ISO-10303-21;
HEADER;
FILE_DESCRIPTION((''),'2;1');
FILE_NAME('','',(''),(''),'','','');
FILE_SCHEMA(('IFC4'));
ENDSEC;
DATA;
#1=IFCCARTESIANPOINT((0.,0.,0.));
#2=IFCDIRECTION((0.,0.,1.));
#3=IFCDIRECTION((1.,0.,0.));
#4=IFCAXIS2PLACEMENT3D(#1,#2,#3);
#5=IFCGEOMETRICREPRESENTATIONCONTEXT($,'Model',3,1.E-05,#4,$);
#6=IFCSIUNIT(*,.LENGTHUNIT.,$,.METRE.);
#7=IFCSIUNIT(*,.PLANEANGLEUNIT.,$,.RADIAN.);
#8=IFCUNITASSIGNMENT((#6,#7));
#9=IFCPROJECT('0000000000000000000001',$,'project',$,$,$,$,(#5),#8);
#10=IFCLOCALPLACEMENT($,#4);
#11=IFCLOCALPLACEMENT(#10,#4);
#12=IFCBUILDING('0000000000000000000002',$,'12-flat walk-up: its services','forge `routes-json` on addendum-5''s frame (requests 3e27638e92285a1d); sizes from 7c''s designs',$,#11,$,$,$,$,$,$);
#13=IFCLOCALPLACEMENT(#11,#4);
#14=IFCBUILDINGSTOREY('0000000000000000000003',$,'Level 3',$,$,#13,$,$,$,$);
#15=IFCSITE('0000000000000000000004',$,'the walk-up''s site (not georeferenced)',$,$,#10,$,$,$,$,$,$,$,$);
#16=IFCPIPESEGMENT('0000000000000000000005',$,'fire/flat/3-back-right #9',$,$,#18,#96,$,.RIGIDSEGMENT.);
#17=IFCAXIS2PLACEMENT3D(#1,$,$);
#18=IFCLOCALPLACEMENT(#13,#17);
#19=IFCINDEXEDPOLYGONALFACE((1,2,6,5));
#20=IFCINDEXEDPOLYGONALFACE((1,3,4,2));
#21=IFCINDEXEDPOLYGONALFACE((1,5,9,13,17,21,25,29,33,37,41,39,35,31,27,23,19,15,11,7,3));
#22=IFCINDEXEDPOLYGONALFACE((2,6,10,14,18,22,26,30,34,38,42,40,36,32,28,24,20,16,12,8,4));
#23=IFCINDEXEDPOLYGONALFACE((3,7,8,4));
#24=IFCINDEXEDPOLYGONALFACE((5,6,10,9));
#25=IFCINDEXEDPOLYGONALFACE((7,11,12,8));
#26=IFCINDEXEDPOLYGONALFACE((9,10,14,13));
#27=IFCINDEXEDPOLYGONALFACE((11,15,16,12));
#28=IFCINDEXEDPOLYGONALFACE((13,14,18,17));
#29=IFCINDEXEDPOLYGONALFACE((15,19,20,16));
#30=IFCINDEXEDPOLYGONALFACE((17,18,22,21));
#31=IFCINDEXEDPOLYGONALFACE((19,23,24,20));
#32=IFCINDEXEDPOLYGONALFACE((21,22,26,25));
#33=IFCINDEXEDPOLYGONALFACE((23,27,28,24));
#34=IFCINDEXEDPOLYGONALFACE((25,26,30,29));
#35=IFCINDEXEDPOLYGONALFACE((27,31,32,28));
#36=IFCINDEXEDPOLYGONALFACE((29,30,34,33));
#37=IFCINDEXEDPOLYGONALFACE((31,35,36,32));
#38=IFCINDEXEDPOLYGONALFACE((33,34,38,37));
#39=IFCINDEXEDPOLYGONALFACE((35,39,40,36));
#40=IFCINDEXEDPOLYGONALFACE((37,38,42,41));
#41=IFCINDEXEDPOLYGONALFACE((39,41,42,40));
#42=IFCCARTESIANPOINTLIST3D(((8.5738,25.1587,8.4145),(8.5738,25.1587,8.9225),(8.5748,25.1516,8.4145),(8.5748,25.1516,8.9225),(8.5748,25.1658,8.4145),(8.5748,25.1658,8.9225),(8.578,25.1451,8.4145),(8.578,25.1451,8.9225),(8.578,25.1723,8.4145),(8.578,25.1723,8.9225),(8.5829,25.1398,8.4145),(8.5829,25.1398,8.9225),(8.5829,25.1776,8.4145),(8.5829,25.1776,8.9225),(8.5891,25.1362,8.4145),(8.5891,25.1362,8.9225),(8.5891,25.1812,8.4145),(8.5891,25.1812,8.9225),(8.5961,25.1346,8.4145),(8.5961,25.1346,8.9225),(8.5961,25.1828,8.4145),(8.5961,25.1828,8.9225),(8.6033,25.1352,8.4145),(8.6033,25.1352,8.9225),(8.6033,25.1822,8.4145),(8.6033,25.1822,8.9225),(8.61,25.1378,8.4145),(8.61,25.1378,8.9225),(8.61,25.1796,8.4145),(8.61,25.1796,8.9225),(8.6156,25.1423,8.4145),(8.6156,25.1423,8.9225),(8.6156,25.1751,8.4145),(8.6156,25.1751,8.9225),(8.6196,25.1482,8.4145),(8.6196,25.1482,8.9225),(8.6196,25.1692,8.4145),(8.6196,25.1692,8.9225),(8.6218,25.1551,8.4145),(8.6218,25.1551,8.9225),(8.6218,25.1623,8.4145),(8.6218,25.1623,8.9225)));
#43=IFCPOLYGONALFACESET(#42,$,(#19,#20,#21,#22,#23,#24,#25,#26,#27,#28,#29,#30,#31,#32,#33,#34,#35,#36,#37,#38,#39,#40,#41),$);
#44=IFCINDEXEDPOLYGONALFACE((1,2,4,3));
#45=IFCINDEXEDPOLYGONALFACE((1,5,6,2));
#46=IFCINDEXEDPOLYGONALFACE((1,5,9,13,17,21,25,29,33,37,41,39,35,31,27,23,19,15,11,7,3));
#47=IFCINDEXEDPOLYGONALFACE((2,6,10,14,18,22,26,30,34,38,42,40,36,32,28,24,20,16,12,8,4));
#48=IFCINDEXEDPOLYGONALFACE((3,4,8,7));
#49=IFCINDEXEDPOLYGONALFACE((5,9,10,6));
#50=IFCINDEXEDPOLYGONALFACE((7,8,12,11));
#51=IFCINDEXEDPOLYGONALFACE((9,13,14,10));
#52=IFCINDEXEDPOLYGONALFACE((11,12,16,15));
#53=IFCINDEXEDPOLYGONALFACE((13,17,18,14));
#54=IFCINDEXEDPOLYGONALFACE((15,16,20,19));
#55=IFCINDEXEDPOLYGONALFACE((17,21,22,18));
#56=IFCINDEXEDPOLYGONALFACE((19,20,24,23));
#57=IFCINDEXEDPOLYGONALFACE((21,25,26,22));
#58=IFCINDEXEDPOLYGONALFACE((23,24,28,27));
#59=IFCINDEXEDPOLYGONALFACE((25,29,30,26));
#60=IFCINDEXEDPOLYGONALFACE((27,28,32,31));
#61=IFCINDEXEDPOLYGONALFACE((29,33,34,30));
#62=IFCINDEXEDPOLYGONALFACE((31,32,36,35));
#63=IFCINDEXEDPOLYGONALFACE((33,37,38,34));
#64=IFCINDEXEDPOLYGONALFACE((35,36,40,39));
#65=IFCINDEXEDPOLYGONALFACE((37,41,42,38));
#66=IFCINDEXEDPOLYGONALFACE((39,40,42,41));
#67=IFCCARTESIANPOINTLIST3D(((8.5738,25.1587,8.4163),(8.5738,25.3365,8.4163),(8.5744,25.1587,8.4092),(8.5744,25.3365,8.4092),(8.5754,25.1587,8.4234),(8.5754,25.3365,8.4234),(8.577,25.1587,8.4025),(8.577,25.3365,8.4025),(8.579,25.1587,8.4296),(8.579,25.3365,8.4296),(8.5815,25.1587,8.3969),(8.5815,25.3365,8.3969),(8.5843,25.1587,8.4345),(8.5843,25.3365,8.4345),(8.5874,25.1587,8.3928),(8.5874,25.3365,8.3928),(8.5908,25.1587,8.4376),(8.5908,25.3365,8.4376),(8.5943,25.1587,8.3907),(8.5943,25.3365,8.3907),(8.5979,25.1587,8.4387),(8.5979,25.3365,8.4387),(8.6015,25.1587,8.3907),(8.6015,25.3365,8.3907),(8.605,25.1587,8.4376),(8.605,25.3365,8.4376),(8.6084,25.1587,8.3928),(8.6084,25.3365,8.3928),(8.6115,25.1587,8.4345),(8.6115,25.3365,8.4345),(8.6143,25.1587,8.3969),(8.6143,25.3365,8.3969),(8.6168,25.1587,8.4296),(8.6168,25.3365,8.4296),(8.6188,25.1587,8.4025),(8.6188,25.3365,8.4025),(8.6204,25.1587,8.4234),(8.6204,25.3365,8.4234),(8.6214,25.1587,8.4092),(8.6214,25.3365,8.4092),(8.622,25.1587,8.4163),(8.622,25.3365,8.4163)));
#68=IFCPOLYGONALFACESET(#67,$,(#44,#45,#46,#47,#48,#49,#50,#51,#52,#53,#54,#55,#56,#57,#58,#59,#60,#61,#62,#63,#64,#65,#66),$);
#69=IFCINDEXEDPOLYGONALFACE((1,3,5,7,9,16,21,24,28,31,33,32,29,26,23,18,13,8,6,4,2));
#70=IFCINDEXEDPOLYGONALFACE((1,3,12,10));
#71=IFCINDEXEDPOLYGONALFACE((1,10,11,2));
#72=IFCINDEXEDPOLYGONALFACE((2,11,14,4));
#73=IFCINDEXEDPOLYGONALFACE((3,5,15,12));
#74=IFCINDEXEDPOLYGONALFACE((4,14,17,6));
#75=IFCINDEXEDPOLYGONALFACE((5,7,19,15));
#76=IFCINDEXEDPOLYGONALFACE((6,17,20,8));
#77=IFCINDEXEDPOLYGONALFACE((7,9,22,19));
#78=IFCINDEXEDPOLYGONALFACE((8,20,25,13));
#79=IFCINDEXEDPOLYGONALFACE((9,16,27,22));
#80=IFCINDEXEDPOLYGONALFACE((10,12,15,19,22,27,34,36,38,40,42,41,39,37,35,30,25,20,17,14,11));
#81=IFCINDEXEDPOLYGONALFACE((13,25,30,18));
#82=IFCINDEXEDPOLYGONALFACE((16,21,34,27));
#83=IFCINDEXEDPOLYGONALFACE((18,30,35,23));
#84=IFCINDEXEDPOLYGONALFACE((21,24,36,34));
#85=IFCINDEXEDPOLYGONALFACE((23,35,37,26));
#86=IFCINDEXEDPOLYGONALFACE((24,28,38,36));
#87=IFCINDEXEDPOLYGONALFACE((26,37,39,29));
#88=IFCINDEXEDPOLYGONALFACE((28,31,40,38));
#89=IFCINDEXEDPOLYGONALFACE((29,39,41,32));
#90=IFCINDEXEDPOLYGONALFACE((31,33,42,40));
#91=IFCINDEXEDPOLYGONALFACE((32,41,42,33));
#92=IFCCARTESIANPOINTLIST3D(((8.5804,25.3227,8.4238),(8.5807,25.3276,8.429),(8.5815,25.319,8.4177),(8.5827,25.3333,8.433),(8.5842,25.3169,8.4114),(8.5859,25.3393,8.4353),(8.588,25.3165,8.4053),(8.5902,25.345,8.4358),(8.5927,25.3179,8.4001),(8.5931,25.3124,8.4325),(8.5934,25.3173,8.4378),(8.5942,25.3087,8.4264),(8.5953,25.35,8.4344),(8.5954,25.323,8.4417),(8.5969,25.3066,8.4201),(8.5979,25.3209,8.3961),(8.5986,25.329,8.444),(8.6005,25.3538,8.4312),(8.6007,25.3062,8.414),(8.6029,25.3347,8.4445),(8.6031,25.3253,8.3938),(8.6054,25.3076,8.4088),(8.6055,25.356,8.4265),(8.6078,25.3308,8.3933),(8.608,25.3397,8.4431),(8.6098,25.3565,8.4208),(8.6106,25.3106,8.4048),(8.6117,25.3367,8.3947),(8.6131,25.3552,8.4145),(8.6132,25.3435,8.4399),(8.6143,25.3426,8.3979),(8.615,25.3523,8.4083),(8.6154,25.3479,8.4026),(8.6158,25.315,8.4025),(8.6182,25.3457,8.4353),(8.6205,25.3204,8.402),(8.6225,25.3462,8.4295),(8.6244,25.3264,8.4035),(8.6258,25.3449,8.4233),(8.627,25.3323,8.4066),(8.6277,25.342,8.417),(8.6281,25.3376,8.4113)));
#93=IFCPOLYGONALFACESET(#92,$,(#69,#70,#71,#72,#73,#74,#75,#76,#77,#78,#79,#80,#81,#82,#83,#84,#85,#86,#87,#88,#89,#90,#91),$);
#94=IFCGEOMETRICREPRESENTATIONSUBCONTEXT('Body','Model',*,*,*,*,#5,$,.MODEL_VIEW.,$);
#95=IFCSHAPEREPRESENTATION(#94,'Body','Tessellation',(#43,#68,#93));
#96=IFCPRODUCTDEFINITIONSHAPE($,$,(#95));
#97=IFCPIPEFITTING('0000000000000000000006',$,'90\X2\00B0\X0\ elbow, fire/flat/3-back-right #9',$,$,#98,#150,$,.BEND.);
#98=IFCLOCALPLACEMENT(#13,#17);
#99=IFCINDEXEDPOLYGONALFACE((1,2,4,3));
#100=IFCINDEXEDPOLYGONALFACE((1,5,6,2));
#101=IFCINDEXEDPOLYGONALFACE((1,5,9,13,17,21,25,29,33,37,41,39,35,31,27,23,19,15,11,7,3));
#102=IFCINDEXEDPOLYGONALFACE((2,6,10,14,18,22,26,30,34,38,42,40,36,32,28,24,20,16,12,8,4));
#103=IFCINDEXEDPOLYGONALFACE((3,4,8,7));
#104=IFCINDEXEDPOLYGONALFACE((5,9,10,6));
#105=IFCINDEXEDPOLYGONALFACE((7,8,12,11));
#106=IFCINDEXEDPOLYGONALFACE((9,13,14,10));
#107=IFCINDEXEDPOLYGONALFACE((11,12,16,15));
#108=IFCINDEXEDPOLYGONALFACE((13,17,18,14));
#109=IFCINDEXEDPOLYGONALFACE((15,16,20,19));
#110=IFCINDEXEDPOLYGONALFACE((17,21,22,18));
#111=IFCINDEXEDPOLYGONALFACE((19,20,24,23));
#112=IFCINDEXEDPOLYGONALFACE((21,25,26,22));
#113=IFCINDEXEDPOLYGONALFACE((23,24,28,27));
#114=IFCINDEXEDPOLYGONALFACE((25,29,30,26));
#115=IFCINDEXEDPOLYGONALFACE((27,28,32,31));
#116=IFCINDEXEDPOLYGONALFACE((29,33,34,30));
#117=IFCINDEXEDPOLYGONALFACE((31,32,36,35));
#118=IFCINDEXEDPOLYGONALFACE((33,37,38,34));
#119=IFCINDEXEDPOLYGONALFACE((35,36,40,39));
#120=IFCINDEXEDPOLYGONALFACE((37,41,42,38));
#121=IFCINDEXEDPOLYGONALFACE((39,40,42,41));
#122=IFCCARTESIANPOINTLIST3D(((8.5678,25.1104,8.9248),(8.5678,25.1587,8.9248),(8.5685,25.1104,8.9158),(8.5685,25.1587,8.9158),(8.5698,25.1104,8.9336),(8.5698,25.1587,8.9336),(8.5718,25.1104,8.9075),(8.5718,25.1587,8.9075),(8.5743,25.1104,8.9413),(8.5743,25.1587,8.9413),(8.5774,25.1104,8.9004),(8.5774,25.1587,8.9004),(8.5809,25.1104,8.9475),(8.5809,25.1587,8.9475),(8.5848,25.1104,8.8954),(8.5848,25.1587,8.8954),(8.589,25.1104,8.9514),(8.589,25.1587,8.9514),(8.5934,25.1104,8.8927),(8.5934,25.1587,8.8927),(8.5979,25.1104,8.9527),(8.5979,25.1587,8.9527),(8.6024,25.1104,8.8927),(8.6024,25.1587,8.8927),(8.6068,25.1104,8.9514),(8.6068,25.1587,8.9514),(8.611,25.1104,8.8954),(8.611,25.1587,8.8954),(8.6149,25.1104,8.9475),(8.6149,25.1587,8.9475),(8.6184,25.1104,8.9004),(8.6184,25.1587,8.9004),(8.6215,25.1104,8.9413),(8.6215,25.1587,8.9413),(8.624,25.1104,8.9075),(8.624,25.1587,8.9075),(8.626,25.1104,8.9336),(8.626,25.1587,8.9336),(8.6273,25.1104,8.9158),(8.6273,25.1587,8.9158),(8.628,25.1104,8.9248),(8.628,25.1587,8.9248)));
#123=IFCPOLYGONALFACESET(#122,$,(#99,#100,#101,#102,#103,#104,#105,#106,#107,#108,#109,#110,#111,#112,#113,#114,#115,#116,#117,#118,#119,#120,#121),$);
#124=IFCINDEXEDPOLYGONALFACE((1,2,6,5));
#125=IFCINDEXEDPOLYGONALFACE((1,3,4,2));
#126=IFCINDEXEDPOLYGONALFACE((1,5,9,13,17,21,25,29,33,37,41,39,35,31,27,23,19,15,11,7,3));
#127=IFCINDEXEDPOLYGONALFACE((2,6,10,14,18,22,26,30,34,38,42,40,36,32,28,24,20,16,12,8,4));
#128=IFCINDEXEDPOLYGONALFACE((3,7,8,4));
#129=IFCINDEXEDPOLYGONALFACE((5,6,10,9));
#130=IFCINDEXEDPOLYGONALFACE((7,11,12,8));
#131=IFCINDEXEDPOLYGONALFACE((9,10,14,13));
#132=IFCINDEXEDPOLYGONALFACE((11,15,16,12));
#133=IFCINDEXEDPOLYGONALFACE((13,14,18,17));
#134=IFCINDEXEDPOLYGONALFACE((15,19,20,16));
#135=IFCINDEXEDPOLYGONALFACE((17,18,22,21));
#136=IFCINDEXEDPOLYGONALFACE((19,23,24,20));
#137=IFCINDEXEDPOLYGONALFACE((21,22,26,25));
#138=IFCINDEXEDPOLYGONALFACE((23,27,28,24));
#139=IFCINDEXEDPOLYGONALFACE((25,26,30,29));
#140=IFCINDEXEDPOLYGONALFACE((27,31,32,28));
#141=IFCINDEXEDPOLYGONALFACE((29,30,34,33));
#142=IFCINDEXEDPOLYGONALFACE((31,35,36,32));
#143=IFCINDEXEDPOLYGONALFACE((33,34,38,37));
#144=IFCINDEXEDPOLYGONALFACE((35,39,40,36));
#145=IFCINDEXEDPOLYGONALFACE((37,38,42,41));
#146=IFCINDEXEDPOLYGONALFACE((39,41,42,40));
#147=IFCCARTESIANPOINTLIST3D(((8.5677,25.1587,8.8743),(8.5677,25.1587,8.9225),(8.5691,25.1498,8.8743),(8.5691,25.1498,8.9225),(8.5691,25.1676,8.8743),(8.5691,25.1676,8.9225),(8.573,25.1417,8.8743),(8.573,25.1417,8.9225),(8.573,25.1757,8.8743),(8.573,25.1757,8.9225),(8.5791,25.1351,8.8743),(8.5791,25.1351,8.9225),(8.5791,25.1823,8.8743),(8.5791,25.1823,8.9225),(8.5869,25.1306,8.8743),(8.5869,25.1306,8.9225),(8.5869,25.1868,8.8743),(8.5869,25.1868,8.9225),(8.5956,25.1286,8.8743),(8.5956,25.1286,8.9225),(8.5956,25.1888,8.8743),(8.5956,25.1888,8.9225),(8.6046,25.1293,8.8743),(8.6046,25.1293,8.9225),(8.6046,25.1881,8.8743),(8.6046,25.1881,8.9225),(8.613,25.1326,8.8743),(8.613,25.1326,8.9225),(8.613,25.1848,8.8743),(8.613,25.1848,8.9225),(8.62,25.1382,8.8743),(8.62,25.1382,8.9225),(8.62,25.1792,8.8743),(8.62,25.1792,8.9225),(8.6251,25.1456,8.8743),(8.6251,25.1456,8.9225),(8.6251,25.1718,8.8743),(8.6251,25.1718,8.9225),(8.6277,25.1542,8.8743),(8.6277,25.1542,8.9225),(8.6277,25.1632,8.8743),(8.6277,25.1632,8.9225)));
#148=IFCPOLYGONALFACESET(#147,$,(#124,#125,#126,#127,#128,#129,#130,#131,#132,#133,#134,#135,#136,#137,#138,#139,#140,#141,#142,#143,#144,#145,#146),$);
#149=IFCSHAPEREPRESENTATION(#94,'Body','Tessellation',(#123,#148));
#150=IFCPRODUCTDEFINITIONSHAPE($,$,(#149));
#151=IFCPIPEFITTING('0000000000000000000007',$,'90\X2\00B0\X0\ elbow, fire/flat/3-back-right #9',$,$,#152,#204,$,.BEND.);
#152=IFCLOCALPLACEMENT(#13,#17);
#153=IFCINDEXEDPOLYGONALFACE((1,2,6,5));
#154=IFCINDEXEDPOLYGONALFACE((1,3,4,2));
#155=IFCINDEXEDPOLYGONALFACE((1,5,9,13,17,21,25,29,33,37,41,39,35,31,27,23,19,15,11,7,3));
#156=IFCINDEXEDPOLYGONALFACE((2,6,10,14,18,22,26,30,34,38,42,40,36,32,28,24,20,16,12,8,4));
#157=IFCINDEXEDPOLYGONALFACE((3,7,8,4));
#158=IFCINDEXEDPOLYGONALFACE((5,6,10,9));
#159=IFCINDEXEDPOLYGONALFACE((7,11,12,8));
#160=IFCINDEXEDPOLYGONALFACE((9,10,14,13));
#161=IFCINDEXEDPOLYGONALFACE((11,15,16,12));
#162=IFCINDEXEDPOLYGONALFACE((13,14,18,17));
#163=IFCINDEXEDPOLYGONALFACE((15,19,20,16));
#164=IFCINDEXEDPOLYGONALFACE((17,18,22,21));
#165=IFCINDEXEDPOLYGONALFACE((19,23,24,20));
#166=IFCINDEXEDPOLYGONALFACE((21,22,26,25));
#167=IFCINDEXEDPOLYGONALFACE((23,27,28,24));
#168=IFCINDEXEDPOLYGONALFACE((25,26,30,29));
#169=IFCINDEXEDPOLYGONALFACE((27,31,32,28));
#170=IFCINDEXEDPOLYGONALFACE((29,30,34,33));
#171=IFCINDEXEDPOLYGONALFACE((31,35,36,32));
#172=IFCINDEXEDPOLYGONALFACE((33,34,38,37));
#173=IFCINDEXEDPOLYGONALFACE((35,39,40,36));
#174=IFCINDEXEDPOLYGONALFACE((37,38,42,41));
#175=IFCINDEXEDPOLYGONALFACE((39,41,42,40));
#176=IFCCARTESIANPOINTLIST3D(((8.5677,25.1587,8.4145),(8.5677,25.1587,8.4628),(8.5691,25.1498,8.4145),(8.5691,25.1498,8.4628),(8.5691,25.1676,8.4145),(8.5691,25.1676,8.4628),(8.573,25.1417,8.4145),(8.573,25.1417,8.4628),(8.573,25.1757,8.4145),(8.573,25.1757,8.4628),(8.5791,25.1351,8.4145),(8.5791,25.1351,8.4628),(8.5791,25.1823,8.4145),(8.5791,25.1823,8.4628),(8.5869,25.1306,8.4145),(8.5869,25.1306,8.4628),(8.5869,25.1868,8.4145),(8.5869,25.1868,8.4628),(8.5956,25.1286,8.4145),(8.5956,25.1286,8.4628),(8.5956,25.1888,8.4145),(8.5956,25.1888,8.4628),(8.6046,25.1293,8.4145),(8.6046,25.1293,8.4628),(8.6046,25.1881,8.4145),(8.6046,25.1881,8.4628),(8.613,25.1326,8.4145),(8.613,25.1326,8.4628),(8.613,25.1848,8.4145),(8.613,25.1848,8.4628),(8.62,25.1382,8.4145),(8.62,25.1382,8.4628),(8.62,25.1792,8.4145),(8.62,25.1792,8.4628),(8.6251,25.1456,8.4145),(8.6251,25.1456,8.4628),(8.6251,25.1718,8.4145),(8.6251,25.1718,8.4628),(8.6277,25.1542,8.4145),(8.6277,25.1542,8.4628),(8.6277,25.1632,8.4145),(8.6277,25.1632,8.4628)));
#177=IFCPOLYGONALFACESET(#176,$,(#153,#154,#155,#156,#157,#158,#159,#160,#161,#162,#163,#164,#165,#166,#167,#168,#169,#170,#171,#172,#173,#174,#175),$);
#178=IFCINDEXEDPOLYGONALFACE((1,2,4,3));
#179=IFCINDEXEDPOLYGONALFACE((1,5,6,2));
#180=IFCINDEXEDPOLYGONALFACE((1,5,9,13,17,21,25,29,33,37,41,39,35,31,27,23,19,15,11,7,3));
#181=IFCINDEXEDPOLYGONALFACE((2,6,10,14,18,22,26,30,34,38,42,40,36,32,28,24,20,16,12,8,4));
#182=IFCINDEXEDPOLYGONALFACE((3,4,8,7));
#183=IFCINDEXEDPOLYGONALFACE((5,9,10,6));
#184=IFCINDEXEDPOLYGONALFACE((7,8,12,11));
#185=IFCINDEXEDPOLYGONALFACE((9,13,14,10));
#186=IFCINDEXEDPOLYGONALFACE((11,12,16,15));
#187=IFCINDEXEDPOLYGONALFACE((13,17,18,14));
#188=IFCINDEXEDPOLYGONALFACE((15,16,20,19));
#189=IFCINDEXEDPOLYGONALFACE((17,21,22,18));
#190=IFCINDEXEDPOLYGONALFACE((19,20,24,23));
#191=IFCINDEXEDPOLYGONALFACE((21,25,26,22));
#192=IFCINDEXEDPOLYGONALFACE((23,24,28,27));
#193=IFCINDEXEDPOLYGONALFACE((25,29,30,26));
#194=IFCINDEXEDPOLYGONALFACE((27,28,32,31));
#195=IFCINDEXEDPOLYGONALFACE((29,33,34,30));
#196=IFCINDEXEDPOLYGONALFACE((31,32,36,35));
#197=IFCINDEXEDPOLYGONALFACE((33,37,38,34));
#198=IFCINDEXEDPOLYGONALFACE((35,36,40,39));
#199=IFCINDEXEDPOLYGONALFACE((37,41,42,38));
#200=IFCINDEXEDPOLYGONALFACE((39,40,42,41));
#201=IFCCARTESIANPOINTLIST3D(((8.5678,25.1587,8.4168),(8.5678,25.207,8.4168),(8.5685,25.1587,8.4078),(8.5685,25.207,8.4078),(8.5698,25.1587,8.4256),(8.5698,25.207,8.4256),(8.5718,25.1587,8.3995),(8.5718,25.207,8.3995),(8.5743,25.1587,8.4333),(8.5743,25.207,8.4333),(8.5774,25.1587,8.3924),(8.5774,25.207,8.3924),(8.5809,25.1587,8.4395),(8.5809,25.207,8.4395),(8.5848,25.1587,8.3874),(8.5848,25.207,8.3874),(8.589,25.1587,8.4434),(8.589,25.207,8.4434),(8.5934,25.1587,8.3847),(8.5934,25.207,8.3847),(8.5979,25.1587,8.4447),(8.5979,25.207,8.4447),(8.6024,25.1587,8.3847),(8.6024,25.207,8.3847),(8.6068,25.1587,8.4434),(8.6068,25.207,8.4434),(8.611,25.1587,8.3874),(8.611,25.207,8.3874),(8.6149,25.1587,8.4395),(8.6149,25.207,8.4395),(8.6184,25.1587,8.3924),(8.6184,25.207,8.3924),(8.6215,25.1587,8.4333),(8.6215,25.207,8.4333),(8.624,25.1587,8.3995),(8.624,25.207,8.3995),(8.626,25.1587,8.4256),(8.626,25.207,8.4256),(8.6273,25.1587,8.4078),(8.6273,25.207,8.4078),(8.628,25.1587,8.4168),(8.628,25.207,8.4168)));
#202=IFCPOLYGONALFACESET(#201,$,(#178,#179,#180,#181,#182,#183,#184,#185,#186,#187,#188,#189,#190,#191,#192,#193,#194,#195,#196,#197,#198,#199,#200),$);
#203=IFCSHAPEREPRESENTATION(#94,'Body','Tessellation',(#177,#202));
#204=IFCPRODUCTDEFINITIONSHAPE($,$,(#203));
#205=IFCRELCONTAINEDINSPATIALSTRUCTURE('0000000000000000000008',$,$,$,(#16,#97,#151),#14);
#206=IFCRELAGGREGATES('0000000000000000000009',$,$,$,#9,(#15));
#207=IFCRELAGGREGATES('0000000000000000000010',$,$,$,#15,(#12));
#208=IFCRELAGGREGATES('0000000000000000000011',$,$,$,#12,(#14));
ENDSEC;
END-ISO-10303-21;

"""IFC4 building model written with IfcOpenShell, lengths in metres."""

from ifc_helpers import new_model, entity, si_unit, frame, origin_with_axes, place, context, subcontext, project, spatial, element, save


model = new_model("IFC4")

# Units and contexts
model_context = context("Model", 3, precision=1e-05, world=origin_with_axes())
body_context = subcontext(model_context, "Body", "Model", "MODEL_VIEW")
ifc_project = project(units=[si_unit("LENGTHUNIT", "METRE"), si_unit("PLANEANGLEUNIT", "RADIAN")], contexts=[model_context])

# Site, building, storey
site_placement = place(None, origin_with_axes())
site = spatial("IfcSite", under=ifc_project, at=site_placement, Name="the walk-up's site (not georeferenced)")
building_placement = place(site_placement, origin_with_axes())
building = spatial("IfcBuilding", under=site, at=building_placement, Name="12-flat walk-up: its services", Description="forge `routes-json` on addendum-5's frame (requests 3e27638e92285a1d); sizes from 7c's designs")
storey_placement = place(building_placement, origin_with_axes())
storey = spatial("IfcBuildingStorey", under=building, at=storey_placement, Name="Level 3")

# Pipe segment
pipe_segment_1_placement = place(storey_placement, frame((8.5979, 25.1587, 8.9225), z_axis=(0.0, 0.0, 1.0), x_axis=(1.0, 0.0, 0.0)))
element("IfcPipeSegment", 1, at=pipe_segment_1_placement, inside=storey, Name="fire/flat/3-back-right #9", PredefinedType="RIGIDSEGMENT", context=body_context, shape_type="AdvancedSweptSolid", body=[
    entity("IfcSweptDiskSolid", entity("IfcPolyline", [entity("IfcCartesianPoint", [0.0, 0.0, 0.0]), entity("IfcCartesianPoint", [0.0, 0.0, -0.508])]), 0.0241),
    entity("IfcSweptDiskSolid", entity("IfcPolyline", [entity("IfcCartesianPoint", [0.0, 0.0, -0.508]), entity("IfcCartesianPoint", [0.0, 0.1778, -0.508])]), 0.0241),
    entity("IfcSweptDiskSolid", entity("IfcPolyline", [entity("IfcCartesianPoint", [0.0, 0.1778, -0.508]), entity("IfcCartesianPoint", [0.0127, 0.1675, -0.4993])]), 0.0241),
])

# Pipe fittings
pipe_fitting_1_placement = place(storey_placement, frame((8.5979, 25.1104, 8.9225), z_axis=(0.0, 0.0, 1.0), x_axis=(1.0, 0.0, 0.0)))
element("IfcPipeFitting", 2, at=pipe_fitting_1_placement, inside=storey, Name="90° elbow, fire/flat/3-back-right #9", PredefinedType="BEND", context=body_context, shape_type="AdvancedSweptSolid", body=[
    entity("IfcSweptDiskSolid", entity("IfcPolyline", [entity("IfcCartesianPoint", [0.0, 0.0, 0.0]), entity("IfcCartesianPoint", [0.0, 0.0483, 0.0])]), 0.0302),
    entity("IfcSweptDiskSolid", entity("IfcPolyline", [entity("IfcCartesianPoint", [0.0, 0.0483, 0.0]), entity("IfcCartesianPoint", [0.0, 0.0483, -0.0483])]), 0.0302),
])
pipe_fitting_2_placement = place(storey_placement, frame((8.5979, 25.1587, 8.4628), z_axis=(0.0, 0.0, 1.0), x_axis=(1.0, 0.0, 0.0)))
element("IfcPipeFitting", 3, at=pipe_fitting_2_placement, inside=storey, Name="90° elbow, fire/flat/3-back-right #9", PredefinedType="BEND", context=body_context, shape_type="AdvancedSweptSolid", body=[
    entity("IfcSweptDiskSolid", entity("IfcPolyline", [entity("IfcCartesianPoint", [0.0, 0.0, 0.0]), entity("IfcCartesianPoint", [0.0, 0.0, -0.0483])]), 0.0302),
    entity("IfcSweptDiskSolid", entity("IfcPolyline", [entity("IfcCartesianPoint", [0.0, 0.0, -0.0483]), entity("IfcCartesianPoint", [0.0, 0.0483, -0.0483])]), 0.0302),
])

save(model, "model.ifc")
